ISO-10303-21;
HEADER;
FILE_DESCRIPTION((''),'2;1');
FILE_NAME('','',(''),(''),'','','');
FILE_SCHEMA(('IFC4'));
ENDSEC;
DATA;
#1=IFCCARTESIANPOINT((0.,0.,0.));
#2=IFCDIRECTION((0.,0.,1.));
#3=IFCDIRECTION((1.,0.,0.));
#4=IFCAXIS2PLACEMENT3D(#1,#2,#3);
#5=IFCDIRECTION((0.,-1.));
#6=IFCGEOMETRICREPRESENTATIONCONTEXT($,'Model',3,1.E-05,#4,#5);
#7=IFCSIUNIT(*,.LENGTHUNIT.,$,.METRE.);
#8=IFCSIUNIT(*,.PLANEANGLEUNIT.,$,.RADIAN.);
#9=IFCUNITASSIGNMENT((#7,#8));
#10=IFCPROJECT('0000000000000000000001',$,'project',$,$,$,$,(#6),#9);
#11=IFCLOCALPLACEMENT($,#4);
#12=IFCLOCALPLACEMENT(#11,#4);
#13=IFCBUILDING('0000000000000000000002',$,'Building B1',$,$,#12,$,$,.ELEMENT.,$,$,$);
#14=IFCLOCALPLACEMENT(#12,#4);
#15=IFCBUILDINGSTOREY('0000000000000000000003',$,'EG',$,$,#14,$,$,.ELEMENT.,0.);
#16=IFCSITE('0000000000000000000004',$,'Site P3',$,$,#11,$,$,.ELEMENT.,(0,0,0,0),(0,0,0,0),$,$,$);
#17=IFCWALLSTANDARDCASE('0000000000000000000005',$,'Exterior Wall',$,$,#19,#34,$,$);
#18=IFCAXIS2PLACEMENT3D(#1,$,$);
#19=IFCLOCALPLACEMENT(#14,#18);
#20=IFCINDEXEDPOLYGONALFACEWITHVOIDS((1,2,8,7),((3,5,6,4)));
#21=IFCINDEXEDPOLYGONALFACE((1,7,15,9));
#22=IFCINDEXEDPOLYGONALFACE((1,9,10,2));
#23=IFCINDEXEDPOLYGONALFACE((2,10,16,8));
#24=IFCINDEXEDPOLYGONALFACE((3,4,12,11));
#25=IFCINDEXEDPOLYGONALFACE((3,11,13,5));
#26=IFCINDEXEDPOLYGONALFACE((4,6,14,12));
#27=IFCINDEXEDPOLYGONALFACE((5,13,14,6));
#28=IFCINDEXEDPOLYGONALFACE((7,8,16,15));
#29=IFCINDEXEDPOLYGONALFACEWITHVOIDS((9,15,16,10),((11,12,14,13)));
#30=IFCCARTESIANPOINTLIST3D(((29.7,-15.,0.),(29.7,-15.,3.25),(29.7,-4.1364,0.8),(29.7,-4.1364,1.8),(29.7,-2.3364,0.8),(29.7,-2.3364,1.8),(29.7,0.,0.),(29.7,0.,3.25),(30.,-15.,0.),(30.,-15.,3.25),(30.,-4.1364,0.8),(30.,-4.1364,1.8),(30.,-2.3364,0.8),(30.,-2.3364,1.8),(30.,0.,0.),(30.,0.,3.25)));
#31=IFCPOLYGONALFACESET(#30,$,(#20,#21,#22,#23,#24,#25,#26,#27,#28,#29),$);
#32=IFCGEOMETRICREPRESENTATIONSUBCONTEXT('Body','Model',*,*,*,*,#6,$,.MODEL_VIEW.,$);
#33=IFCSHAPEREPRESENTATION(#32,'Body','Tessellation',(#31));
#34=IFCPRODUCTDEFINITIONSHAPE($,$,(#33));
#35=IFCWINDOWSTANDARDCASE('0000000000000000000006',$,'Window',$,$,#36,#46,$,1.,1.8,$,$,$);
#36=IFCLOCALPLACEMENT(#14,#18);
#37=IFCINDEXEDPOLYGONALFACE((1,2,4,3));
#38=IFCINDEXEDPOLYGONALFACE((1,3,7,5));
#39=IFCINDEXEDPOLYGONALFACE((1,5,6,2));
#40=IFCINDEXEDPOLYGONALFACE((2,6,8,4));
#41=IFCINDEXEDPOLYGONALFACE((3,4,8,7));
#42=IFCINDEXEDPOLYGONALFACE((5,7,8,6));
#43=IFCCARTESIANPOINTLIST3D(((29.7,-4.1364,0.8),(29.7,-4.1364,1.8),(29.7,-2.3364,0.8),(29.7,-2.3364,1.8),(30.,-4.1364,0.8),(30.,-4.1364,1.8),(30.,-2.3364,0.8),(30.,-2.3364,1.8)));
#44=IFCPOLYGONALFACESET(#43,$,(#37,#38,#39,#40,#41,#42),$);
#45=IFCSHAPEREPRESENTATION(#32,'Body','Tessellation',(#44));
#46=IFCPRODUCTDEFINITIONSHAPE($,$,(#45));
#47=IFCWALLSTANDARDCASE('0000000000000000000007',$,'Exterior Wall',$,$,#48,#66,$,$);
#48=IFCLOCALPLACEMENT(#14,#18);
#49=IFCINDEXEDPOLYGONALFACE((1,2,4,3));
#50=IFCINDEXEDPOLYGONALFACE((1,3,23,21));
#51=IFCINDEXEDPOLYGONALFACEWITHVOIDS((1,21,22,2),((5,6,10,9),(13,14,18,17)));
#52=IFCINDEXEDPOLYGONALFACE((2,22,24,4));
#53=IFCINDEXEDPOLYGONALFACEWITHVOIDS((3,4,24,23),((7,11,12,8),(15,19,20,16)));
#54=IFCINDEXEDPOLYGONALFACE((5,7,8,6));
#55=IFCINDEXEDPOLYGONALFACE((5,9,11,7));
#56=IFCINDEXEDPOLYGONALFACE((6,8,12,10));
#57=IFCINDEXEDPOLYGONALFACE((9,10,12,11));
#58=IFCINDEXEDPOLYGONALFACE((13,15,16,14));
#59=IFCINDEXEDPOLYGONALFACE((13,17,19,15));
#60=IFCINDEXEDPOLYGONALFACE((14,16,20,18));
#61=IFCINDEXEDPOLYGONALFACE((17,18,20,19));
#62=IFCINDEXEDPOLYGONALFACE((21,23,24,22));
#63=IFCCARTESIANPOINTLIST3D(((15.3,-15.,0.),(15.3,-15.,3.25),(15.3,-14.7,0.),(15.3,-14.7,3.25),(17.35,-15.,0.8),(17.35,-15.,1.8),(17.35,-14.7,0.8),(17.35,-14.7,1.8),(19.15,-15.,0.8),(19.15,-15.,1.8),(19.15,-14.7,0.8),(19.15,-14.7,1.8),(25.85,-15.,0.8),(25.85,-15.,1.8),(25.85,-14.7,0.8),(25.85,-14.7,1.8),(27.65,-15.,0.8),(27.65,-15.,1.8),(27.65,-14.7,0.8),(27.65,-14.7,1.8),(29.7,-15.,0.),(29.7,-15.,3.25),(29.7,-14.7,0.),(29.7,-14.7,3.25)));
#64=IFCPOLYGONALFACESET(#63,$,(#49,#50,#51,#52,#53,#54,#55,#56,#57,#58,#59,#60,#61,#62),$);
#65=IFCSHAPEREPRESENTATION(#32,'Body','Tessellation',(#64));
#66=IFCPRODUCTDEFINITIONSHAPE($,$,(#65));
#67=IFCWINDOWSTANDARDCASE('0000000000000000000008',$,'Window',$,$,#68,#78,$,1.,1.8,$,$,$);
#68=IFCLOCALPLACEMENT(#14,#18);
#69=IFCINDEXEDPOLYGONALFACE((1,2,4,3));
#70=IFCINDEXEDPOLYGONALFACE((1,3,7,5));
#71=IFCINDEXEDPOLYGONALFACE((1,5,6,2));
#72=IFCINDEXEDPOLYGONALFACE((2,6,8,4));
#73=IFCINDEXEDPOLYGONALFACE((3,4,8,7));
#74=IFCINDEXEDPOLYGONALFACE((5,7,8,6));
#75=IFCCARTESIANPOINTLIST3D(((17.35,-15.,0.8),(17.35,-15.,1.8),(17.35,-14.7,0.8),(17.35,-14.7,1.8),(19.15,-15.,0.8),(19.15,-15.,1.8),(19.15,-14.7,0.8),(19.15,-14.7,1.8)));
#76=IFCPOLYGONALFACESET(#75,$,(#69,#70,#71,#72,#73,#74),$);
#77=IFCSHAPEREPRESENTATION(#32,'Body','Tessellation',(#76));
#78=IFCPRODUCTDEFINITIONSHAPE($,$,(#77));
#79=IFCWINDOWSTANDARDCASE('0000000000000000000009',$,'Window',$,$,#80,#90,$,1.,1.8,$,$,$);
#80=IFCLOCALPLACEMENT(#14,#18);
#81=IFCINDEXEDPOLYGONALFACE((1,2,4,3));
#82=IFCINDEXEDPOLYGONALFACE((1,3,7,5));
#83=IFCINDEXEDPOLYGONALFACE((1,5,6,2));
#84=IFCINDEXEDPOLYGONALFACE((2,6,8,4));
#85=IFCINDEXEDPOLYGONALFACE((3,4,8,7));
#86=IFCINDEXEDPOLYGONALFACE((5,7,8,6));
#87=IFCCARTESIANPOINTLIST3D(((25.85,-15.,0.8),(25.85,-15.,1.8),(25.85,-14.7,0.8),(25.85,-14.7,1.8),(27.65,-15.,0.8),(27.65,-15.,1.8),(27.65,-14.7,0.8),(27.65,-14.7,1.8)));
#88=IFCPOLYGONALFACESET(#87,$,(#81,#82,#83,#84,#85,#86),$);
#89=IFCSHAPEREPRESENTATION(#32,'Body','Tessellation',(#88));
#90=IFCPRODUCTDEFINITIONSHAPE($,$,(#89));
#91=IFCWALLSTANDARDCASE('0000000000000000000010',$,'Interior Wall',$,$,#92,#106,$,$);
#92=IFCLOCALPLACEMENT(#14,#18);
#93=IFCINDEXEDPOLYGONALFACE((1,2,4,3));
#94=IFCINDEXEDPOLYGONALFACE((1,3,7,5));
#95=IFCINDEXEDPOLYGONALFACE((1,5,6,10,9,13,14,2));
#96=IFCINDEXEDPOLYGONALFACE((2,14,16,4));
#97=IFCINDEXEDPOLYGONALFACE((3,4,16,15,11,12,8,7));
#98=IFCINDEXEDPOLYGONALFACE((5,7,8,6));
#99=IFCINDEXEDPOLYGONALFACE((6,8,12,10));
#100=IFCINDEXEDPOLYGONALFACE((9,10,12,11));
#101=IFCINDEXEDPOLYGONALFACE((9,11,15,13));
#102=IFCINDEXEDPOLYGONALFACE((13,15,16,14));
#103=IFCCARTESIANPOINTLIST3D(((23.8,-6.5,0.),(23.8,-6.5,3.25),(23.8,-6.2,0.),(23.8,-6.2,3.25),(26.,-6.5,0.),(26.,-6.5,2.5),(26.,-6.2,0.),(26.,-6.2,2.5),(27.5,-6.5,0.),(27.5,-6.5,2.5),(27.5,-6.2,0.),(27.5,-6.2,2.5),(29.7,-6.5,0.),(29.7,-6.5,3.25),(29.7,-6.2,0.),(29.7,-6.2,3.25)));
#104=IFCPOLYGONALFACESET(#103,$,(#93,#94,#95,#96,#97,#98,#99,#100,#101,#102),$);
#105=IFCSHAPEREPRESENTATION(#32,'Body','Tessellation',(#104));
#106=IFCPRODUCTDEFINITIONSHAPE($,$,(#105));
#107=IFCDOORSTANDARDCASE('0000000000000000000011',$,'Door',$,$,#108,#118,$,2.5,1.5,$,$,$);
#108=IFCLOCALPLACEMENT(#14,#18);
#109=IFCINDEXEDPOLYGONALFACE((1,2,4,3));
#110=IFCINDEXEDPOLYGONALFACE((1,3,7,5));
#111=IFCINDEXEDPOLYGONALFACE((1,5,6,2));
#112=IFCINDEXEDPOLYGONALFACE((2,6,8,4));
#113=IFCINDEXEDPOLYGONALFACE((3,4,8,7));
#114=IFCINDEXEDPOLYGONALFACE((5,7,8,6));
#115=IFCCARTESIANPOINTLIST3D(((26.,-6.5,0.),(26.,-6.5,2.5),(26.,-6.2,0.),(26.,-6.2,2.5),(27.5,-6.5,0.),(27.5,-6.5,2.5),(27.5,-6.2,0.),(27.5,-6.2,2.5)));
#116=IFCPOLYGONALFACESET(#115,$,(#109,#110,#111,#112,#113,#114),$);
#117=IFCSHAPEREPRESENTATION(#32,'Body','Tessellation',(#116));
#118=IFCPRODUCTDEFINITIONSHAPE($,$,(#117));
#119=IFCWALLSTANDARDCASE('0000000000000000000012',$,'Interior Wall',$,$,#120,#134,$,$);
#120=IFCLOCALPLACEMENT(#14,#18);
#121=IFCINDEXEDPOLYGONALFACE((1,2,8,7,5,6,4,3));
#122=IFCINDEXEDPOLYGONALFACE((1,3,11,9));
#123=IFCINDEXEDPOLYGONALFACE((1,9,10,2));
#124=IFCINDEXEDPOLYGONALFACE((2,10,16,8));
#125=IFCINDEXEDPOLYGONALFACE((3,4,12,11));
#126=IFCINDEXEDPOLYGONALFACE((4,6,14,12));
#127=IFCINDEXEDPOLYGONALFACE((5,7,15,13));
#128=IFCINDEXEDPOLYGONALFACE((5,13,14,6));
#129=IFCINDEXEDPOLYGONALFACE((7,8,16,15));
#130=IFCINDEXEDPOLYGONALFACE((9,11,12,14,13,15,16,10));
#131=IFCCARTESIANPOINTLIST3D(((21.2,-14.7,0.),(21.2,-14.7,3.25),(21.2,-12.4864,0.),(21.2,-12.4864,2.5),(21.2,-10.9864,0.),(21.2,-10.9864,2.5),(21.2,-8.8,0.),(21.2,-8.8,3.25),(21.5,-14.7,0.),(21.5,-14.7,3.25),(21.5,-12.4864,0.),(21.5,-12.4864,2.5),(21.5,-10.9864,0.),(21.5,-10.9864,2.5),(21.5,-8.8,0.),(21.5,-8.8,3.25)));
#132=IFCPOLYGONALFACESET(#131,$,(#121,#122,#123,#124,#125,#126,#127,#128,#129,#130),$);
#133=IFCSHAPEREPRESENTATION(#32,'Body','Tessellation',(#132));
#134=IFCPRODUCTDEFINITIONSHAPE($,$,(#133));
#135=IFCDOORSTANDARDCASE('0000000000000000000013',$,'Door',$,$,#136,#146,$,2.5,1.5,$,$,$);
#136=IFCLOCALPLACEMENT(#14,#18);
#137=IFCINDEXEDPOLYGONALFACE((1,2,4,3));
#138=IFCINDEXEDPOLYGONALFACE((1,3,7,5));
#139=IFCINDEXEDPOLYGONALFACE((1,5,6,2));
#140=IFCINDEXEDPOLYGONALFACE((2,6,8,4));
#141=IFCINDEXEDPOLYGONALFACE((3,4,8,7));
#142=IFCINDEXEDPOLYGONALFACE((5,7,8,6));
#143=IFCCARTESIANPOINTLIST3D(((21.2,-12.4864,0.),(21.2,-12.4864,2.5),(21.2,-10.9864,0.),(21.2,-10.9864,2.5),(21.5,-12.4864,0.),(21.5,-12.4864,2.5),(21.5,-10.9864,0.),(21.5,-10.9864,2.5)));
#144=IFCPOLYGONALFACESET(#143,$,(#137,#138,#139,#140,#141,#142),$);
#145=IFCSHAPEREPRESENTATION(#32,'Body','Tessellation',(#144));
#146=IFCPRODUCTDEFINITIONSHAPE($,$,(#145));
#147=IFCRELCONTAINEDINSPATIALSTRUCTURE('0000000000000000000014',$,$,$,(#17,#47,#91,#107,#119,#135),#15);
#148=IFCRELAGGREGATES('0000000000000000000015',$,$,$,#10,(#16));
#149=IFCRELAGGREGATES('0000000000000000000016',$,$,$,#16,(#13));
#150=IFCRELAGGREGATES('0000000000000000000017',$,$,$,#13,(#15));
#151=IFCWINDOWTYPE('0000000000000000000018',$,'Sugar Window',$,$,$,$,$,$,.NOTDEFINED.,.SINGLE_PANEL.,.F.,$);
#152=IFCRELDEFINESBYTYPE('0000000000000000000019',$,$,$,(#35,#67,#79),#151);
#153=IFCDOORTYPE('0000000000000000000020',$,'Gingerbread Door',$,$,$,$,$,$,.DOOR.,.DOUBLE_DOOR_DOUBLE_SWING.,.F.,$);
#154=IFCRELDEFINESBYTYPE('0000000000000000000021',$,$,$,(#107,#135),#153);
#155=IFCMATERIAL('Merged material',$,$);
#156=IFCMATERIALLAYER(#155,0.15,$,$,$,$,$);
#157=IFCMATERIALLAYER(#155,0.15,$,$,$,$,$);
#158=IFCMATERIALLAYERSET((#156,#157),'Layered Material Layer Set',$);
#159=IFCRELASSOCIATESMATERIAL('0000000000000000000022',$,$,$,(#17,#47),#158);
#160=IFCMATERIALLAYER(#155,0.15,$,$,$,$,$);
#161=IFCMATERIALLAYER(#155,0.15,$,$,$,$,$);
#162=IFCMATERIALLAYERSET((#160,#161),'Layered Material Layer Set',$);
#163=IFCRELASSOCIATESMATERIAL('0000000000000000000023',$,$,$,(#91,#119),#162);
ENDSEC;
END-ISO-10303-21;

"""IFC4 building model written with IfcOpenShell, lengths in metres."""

from ifc_helpers import new_model, si_unit, direction, frame, origin_with_axes, place, context, subcontext, project, spatial, polyline, outline, extrude, source, transform, mapped, material, layer, layer_set, layer_usage, type_object, element, fill, save


model = new_model("IFC4")

# Units and contexts
model_context = context("Model", 3, precision=1e-05, world=origin_with_axes(), true_north=direction((0.0, -1.0)))
body_context = subcontext(model_context, "Body", "Model", "MODEL_VIEW")
ifc_project = project(units=[si_unit("LENGTHUNIT", "METRE"), si_unit("PLANEANGLEUNIT", "RADIAN")], contexts=[model_context])

# Site, building, storey
site_placement = place(None, origin_with_axes())
site = spatial("IfcSite", under=ifc_project, at=site_placement, Name="Site P3", CompositionType="ELEMENT", RefLatitude=(0, 0, 0, 0), RefLongitude=(0, 0, 0, 0))
building_placement = place(site_placement, origin_with_axes())
building = spatial("IfcBuilding", under=site, at=building_placement, Name="Building B1", CompositionType="ELEMENT")
storey_placement = place(building_placement, origin_with_axes())
storey = spatial("IfcBuildingStorey", under=building, at=storey_placement, Name="EG", CompositionType="ELEMENT", Elevation=0.0)

# Wall, opening, window
ifc_material = material(Name="Merged material")
ifc_layer_1 = layer(ifc_material, 0.15)
ifc_layer_2 = layer(ifc_material, 0.15)
ifc_layer_set_1 = layer_set([ifc_layer_1, ifc_layer_2], Name="Layered Material Layer Set")
ifc_layer_usage_1 = layer_usage(ifc_layer_set_1, "AXIS2", "POSITIVE", -0.15)
wall_1_placement = place(storey_placement, frame((29.85, -15.0, 0.0), z_axis=(0.0, 0.0, 1.0), x_axis=(0.0, 1.0, 0.0)))
wall_1 = element("IfcWallStandardCase", 1, at=wall_1_placement, inside=storey, material=ifc_layer_usage_1, Name="Exterior Wall", context=body_context, shape_type="SweptSolid", body=[
    extrude(outline(polyline([(0.0, 0.15), (15.0, 0.15), (15.0, -0.15), (0.0, -0.15), (0.0, 0.15)])), origin_with_axes(), (0.0, 0.0, 1.0), 3.25),
])
opening_1_placement = place(wall_1_placement, frame((10.8636, 0.0, 0.8), z_axis=(0.0, 0.0, 1.0), x_axis=(1.0, 0.0, 0.0)))
opening_1 = element("IfcOpeningStandardCase", 2, at=opening_1_placement, cuts=wall_1, context=body_context, shape_type="SweptSolid", body=[
    extrude(outline(polyline([(0.0, 0.0), (0.0, 1.8), (1.0, 1.8), (1.0, 0.0), (0.0, 0.0)])), frame((0.0, -0.15, 0.0), z_axis=(0.0, 1.0, 0.0), x_axis=(0.0, 0.0, 1.0)), (0.0, 0.0, 1.0), 0.3),
])
window_type = type_object("IfcWindowType", Name="Sugar Window", ParameterTakesPrecedence=False, PartitioningType="SINGLE_PANEL", PredefinedType="NOTDEFINED")
shared_shape_1 = source(origin_with_axes(), body_context, "Body", "SweptSolid", [
    extrude(outline(polyline([(0.0, 0.0), (0.0, 1.8), (1.0, 1.8), (1.0, 0.0), (0.0, 0.0)])), frame((0.0, -0.15, 0.0), z_axis=(0.0, 1.0, 0.0), x_axis=(0.0, 0.0, 1.0)), (0.0, 0.0, 1.0), 0.3),
])
window_1_placement = place(opening_1_placement, origin_with_axes())
window_1 = element("IfcWindowStandardCase", 3, at=window_1_placement, type_object=window_type, Name="Window", OverallHeight=1.0, OverallWidth=1.8, context=body_context, shape_type="MappedRepresentation", body=[
    mapped(shared_shape_1, transform((0.0, 0.0, 0.0))),
])
fill(opening_1, window_1)

# Wall, openings, windows
wall_2_placement = place(storey_placement, frame((15.3, -14.85, 0.0), z_axis=(0.0, 0.0, 1.0), x_axis=(1.0, 0.0, 0.0)))
wall_2 = element("IfcWallStandardCase", 4, at=wall_2_placement, inside=storey, material=ifc_layer_usage_1, Name="Exterior Wall", context=body_context, shape_type="SweptSolid", body=[
    extrude(outline(polyline([(0.0, 0.15), (14.4, 0.15), (14.4, -0.15), (0.0, -0.15), (0.0, 0.15)])), origin_with_axes(), (0.0, 0.0, 1.0), 3.25),
])
opening_2_placement = place(wall_2_placement, frame((2.05, 0.0, 0.8), z_axis=(0.0, 0.0, 1.0), x_axis=(1.0, 0.0, 0.0)))
opening_2 = element("IfcOpeningStandardCase", 5, at=opening_2_placement, cuts=wall_2, context=body_context, shape_type="SweptSolid", body=[
    extrude(outline(polyline([(0.0, 0.0), (0.0, 1.8), (1.0, 1.8), (1.0, 0.0), (0.0, 0.0)])), frame((0.0, -0.15, 0.0), z_axis=(0.0, 1.0, 0.0), x_axis=(0.0, 0.0, 1.0)), (0.0, 0.0, 1.0), 0.3),
])
opening_3_placement = place(wall_2_placement, frame((10.55, 0.0, 0.8), z_axis=(0.0, 0.0, 1.0), x_axis=(1.0, 0.0, 0.0)))
opening_3 = element("IfcOpeningStandardCase", 6, at=opening_3_placement, cuts=wall_2, context=body_context, shape_type="SweptSolid", body=[
    extrude(outline(polyline([(0.0, 0.0), (0.0, 1.8), (1.0, 1.8), (1.0, 0.0), (0.0, 0.0)])), frame((0.0, -0.15, 0.0), z_axis=(0.0, 1.0, 0.0), x_axis=(0.0, 0.0, 1.0)), (0.0, 0.0, 1.0), 0.3),
])
window_2_placement = place(opening_2_placement, origin_with_axes())
window_2 = element("IfcWindowStandardCase", 7, at=window_2_placement, type_object=window_type, Name="Window", OverallHeight=1.0, OverallWidth=1.8, context=body_context, shape_type="MappedRepresentation", body=[
    mapped(shared_shape_1, transform((0.0, 0.0, 0.0))),
])
fill(opening_2, window_2)
window_3_placement = place(opening_3_placement, origin_with_axes())
window_3 = element("IfcWindowStandardCase", 8, at=window_3_placement, type_object=window_type, Name="Window", OverallHeight=1.0, OverallWidth=1.8, context=body_context, shape_type="MappedRepresentation", body=[
    mapped(shared_shape_1, transform((0.0, 0.0, 0.0))),
])
fill(opening_3, window_3)

# Walls, openings, doors
ifc_layer_3 = layer(ifc_material, 0.15)
ifc_layer_4 = layer(ifc_material, 0.15)
ifc_layer_set_2 = layer_set([ifc_layer_3, ifc_layer_4], Name="Layered Material Layer Set")
ifc_layer_usage_2 = layer_usage(ifc_layer_set_2, "AXIS2", "POSITIVE", -0.15)
wall_3_placement = place(storey_placement, frame((23.8, -6.35, 0.0), z_axis=(0.0, 0.0, 1.0), x_axis=(1.0, 0.0, 0.0)))
wall_3 = element("IfcWallStandardCase", 9, at=wall_3_placement, inside=storey, material=ifc_layer_usage_2, Name="Interior Wall", context=body_context, shape_type="SweptSolid", body=[
    extrude(outline(polyline([(0.0, 0.15), (5.9, 0.15), (5.9, -0.15), (0.0, -0.15), (0.0, 0.15)])), origin_with_axes(), (0.0, 0.0, 1.0), 3.25),
])
opening_4_placement = place(wall_3_placement, frame((2.2, 0.0, 0.0), z_axis=(0.0, 0.0, 1.0), x_axis=(1.0, 0.0, 0.0)))
opening_4 = element("IfcOpeningStandardCase", 10, at=opening_4_placement, cuts=wall_3, context=body_context, shape_type="SweptSolid", body=[
    extrude(outline(polyline([(0.0, 0.0), (0.0, 1.5), (2.5, 1.5), (2.5, 0.0), (0.0, 0.0)])), frame((0.0, -0.15, 0.0), z_axis=(0.0, 1.0, 0.0), x_axis=(0.0, 0.0, 1.0)), (0.0, 0.0, 1.0), 0.3),
])
door_type = type_object("IfcDoorType", Name="Gingerbread Door", OperationType="DOUBLE_DOOR_DOUBLE_SWING", ParameterTakesPrecedence=False, PredefinedType="DOOR")
shared_shape_2 = source(origin_with_axes(), body_context, "Body", "SweptSolid", [
    extrude(outline(polyline([(0.0, 0.0), (0.0, 1.5), (2.5, 1.5), (2.5, 0.0), (0.0, 0.0)])), frame((0.0, -0.15, 0.0), z_axis=(0.0, 1.0, 0.0), x_axis=(0.0, 0.0, 1.0)), (0.0, 0.0, 1.0), 0.3),
])
door_1_placement = place(opening_4_placement, origin_with_axes())
door_1 = element("IfcDoorStandardCase", 11, at=door_1_placement, inside=storey, type_object=door_type, Name="Door", OverallHeight=2.5, OverallWidth=1.5, context=body_context, shape_type="MappedRepresentation", body=[
    mapped(shared_shape_2, transform((0.0, 0.0, 0.0))),
])
fill(opening_4, door_1)
wall_4_placement = place(storey_placement, frame((21.35, -8.8, 0.0), z_axis=(0.0, 0.0, 1.0), x_axis=(0.0, -1.0, 0.0)))
wall_4 = element("IfcWallStandardCase", 12, at=wall_4_placement, inside=storey, material=ifc_layer_usage_2, Name="Interior Wall", context=body_context, shape_type="SweptSolid", body=[
    extrude(outline(polyline([(0.0, 0.15), (5.9, 0.15), (5.9, -0.15), (0.0, -0.15), (0.0, 0.15)])), origin_with_axes(), (0.0, 0.0, 1.0), 3.25),
])
opening_5_placement = place(wall_4_placement, frame((2.1864, 0.0, 0.0), z_axis=(0.0, 0.0, 1.0), x_axis=(1.0, 0.0, 0.0)))
opening_5 = element("IfcOpeningStandardCase", 13, at=opening_5_placement, cuts=wall_4, context=body_context, shape_type="SweptSolid", body=[
    extrude(outline(polyline([(0.0, 0.0), (0.0, 1.5), (2.5, 1.5), (2.5, 0.0), (0.0, 0.0)])), frame((0.0, -0.15, 0.0), z_axis=(0.0, 1.0, 0.0), x_axis=(0.0, 0.0, 1.0)), (0.0, 0.0, 1.0), 0.3),
])
door_2_placement = place(opening_5_placement, origin_with_axes())
door_2 = element("IfcDoorStandardCase", 14, at=door_2_placement, inside=storey, type_object=door_type, Name="Door", OverallHeight=2.5, OverallWidth=1.5, context=body_context, shape_type="MappedRepresentation", body=[
    mapped(shared_shape_2, transform((0.0, 0.0, 0.0))),
])
fill(opening_5, door_2)

save(model, "model.ifc")
